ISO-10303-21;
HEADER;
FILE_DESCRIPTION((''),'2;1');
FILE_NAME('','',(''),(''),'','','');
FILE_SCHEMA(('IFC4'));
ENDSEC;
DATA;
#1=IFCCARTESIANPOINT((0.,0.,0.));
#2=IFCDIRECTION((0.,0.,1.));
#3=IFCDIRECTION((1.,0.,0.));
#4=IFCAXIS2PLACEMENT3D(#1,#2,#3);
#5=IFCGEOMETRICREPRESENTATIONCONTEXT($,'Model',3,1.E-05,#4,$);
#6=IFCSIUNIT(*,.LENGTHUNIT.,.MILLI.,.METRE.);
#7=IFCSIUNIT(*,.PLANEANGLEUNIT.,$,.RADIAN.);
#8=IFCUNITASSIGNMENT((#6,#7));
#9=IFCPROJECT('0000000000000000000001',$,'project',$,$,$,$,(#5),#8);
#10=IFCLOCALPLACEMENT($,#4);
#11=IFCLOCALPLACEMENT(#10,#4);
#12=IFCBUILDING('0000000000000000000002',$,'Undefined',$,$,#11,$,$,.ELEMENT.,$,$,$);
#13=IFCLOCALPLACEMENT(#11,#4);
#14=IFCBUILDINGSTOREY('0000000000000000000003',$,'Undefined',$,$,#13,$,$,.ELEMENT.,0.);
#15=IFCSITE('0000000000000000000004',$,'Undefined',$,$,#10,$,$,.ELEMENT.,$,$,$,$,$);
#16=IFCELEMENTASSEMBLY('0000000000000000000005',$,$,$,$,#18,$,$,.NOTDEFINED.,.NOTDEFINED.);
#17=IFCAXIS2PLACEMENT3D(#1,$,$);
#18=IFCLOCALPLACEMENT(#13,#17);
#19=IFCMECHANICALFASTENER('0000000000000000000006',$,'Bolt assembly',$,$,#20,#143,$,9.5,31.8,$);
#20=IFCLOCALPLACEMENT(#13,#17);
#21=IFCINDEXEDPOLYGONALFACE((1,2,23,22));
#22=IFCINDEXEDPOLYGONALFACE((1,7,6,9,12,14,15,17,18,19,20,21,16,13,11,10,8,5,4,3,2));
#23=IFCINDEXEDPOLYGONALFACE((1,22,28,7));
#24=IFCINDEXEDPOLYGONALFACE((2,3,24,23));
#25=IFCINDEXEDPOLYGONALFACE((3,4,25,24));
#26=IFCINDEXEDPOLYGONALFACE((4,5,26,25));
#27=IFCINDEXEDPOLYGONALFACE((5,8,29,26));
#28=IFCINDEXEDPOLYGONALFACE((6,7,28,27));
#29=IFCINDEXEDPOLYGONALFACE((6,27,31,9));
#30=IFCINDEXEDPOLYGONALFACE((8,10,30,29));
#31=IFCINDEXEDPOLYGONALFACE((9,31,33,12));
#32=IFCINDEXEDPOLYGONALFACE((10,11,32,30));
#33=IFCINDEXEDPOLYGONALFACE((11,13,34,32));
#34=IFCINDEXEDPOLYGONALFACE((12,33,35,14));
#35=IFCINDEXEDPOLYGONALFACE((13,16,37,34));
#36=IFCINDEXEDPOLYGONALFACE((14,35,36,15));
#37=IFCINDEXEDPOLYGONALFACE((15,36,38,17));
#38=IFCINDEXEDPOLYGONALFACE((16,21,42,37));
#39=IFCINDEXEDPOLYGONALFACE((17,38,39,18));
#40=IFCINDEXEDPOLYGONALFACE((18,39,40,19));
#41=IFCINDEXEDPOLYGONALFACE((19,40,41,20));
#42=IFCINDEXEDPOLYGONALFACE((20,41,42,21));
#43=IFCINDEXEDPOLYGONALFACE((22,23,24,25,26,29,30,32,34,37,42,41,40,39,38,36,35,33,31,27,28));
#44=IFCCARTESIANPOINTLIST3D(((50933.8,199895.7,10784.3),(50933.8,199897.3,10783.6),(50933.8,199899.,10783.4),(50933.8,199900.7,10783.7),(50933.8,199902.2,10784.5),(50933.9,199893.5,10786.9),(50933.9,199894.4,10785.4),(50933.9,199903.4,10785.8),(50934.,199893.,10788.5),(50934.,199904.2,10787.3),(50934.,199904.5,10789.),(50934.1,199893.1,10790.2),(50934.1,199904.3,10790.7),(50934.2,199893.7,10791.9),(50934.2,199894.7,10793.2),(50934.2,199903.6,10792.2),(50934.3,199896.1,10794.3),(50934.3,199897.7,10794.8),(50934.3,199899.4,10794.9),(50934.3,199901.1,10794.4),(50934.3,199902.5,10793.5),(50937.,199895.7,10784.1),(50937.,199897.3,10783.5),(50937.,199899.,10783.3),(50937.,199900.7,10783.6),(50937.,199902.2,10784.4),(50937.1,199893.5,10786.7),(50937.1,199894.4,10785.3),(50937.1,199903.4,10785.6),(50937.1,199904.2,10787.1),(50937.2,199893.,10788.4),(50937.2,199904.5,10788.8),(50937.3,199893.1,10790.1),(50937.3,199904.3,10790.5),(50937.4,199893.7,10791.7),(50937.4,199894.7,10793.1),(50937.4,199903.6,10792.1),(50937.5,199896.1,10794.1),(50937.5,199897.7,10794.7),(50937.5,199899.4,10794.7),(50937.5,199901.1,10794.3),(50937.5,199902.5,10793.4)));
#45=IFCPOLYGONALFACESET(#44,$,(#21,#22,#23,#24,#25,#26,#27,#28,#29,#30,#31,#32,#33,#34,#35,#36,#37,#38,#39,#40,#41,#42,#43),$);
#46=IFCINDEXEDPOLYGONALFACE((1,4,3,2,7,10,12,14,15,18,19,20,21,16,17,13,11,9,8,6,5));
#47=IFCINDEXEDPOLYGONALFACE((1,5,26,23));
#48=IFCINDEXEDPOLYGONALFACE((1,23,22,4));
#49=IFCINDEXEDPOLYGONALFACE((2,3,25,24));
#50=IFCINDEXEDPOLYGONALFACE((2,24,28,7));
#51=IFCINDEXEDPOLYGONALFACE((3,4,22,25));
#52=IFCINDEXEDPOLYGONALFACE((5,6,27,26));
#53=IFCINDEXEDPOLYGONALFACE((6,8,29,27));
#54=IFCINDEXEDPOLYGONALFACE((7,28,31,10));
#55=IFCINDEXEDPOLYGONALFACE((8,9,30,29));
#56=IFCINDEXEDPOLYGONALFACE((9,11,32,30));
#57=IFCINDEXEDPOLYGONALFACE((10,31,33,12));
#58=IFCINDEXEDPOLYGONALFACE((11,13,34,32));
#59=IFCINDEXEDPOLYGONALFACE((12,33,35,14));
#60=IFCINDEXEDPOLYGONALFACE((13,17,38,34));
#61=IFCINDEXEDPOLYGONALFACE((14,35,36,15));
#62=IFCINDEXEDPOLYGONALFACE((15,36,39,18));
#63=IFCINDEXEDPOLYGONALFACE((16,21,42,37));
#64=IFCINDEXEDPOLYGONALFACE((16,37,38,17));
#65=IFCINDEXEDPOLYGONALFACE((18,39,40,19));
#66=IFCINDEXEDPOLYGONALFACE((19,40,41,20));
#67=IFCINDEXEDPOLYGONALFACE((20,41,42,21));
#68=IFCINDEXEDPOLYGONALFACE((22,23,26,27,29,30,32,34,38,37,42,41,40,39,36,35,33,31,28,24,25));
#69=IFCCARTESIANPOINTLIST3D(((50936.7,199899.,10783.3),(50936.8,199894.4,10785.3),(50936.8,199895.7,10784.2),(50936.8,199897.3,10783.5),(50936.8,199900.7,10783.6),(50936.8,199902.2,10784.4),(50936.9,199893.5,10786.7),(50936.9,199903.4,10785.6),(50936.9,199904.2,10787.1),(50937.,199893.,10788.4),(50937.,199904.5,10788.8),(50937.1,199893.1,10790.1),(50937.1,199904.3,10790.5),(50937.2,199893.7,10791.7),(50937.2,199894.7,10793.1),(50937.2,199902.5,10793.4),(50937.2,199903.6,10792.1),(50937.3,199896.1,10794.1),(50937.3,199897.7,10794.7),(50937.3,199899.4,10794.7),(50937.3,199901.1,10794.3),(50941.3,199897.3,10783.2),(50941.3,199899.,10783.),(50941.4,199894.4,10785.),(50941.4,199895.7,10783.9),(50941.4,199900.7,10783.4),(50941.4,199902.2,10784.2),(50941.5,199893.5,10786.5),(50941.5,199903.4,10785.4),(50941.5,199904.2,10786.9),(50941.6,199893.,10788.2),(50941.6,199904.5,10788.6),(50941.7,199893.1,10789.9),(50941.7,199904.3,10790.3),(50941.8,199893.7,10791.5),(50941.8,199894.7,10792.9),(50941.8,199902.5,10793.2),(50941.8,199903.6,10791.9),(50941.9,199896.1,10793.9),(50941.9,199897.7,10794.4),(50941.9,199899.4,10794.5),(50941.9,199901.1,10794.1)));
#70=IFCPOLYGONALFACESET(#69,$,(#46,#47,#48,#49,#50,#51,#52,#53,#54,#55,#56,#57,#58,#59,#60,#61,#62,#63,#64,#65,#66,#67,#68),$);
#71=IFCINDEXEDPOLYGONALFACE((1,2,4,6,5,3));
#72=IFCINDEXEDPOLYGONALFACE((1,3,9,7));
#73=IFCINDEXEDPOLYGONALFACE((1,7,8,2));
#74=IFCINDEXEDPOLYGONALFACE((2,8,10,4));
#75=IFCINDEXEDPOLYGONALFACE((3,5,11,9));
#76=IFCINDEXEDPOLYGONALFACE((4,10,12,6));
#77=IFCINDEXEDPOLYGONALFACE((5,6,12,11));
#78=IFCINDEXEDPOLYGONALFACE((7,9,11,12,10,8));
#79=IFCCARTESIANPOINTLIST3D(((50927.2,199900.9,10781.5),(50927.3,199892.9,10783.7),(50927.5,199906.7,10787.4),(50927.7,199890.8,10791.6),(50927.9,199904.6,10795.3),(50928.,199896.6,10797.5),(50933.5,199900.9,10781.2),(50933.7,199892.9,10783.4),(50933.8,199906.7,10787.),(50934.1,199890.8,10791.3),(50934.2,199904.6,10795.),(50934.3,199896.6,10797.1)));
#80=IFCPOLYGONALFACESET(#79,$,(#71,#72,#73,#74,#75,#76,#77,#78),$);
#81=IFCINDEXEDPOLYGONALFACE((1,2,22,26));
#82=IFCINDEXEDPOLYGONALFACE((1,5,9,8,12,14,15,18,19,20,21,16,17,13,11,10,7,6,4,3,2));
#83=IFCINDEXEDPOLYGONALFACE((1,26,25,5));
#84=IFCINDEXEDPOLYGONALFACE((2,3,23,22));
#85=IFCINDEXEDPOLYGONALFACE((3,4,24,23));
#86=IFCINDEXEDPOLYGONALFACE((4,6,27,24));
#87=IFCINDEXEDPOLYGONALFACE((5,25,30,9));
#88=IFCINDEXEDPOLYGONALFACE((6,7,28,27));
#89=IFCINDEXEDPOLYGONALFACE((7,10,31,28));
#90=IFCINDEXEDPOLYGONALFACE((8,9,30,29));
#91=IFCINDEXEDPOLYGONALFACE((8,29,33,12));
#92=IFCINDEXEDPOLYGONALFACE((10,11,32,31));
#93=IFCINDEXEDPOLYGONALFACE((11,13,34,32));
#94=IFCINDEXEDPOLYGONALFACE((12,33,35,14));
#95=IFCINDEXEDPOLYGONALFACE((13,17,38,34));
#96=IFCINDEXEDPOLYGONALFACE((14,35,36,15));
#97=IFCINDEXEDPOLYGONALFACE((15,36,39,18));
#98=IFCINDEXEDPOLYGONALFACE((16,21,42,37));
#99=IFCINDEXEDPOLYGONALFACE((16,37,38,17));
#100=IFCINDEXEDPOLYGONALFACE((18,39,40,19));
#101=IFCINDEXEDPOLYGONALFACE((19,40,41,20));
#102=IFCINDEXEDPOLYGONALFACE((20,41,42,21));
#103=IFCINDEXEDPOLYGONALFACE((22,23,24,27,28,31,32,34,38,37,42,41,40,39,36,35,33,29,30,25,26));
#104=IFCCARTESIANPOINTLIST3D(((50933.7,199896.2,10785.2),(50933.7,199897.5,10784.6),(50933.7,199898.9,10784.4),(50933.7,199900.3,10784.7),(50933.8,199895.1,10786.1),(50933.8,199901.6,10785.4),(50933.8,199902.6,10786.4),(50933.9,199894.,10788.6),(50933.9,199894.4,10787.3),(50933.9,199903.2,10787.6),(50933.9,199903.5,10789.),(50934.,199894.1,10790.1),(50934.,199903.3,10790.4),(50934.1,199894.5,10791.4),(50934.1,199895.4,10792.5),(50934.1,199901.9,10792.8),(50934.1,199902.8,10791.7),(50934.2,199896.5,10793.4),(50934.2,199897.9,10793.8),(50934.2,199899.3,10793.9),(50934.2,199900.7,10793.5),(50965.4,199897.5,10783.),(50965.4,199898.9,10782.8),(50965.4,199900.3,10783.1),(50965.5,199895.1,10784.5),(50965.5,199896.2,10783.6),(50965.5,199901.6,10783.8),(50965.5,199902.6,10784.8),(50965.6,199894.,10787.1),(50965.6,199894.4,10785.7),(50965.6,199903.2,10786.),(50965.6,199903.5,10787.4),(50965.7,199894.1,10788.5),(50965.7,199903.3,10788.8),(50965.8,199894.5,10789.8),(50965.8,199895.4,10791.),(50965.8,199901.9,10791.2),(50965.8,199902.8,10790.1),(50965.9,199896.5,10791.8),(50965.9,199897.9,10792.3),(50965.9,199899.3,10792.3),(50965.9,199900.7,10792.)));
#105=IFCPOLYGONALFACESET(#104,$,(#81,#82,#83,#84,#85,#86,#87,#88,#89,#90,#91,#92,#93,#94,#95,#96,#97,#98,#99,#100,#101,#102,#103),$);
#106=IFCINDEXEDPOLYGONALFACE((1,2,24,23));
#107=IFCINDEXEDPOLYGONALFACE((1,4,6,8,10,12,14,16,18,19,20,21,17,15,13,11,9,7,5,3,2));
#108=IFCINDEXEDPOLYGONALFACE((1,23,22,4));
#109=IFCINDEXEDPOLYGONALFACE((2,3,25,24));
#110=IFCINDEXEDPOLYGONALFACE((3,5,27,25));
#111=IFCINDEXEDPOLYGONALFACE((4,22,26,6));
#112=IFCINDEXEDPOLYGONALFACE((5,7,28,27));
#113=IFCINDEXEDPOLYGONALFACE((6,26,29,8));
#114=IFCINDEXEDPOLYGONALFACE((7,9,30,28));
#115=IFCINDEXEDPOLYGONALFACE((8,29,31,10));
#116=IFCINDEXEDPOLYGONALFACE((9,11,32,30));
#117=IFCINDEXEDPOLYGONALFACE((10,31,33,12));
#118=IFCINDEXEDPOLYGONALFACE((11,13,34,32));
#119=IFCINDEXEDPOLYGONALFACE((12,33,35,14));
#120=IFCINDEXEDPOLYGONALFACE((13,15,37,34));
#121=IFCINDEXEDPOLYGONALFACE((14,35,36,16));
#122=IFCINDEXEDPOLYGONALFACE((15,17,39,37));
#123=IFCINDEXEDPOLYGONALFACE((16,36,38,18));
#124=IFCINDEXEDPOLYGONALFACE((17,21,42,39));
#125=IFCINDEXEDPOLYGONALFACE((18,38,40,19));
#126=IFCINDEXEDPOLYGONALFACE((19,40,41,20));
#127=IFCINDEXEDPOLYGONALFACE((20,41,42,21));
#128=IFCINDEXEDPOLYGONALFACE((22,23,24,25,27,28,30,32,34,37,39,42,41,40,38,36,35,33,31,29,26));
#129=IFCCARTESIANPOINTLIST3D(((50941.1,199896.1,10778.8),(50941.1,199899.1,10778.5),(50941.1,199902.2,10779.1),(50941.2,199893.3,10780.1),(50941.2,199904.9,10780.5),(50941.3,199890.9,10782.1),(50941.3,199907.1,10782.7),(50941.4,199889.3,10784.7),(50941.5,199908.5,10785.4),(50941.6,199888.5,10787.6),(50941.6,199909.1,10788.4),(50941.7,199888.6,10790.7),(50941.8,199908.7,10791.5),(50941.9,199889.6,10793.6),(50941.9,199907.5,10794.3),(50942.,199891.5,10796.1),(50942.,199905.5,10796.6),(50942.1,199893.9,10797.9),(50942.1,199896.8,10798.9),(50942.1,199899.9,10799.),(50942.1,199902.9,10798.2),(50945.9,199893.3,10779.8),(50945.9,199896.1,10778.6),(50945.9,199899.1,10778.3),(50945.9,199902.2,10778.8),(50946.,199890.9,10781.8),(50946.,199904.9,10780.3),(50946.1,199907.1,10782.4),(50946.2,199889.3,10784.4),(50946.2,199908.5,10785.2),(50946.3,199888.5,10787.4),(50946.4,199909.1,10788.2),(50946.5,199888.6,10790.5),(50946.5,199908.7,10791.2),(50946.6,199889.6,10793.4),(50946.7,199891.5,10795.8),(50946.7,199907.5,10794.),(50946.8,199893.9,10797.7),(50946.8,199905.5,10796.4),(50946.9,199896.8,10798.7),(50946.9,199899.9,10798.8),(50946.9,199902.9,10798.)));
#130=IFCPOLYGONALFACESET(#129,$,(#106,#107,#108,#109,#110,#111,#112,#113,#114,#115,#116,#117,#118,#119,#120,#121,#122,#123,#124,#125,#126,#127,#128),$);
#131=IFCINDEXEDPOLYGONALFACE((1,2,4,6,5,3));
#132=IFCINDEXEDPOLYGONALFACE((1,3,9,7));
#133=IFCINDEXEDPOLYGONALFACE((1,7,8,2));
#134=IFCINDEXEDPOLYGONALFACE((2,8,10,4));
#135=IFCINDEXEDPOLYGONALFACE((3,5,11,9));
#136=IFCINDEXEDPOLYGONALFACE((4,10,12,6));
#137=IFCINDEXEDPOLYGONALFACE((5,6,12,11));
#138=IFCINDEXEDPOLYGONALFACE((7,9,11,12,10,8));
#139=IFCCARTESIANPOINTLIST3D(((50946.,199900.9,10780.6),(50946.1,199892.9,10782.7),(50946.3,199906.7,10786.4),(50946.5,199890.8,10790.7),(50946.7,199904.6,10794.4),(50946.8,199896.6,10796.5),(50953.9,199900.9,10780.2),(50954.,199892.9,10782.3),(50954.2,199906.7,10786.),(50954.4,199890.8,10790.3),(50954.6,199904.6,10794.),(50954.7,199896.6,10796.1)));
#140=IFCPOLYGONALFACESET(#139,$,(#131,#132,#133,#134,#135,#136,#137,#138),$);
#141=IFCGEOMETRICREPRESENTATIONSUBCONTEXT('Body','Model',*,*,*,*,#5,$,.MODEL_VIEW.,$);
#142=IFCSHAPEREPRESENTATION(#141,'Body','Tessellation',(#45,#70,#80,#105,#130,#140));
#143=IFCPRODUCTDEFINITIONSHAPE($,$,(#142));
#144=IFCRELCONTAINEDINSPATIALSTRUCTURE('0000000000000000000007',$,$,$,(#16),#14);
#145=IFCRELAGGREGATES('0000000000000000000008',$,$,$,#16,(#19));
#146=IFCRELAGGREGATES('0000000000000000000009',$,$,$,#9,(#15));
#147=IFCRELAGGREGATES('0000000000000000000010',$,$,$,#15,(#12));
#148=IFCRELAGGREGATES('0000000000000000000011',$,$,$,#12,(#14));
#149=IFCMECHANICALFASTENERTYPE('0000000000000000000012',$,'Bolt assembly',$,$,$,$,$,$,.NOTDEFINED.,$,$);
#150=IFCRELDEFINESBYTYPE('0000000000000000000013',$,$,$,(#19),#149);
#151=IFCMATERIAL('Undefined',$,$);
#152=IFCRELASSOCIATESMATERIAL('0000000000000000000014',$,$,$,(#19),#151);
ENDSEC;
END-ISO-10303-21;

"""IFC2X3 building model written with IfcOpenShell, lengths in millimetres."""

from ifc_helpers import new_model, si_unit, frame, origin_with_axes, origin_2d_with_axis, place, context, subcontext, project, spatial, polyline, circle, outline, extrude, source, transform, mapped, material, type_object, element, aggregate, save


model = new_model("IFC2X3")

# Units and contexts
model_context = context("Model", 3, precision=1e-05, world=origin_with_axes())
body_context = subcontext(model_context, "Body", "Model", "MODEL_VIEW")
ifc_project = project(units=[si_unit("LENGTHUNIT", "METRE", prefix="MILLI"), si_unit("PLANEANGLEUNIT", "RADIAN")], contexts=[model_context])

# Site, building, storey
site_placement = place(None, origin_with_axes())
site = spatial("IfcSite", under=ifc_project, at=site_placement, Name="Undefined", CompositionType="ELEMENT")
building_placement = place(site_placement, origin_with_axes())
building = spatial("IfcBuilding", under=site, at=building_placement, Name="Undefined", CompositionType="ELEMENT")
storey_placement = place(building_placement, origin_with_axes())
storey = spatial("IfcBuildingStorey", under=building, at=storey_placement, Name="Undefined", CompositionType="ELEMENT", Elevation=0.0)

# Shared definitions
ifc_material_1 = material(Name="Undefined")
mechanical_fastener_type = type_object("IfcMechanicalFastenerType", Name="Bolt assembly")

# Element assembly, mechanical fastener
assembly_1_placement = place(storey_placement, origin_with_axes())
assembly_1 = element("IfcElementAssembly", 1, at=assembly_1_placement, inside=storey, AssemblyPlace="NOTDEFINED", PredefinedType="NOTDEFINED")
shared_shape_1 = source(origin_with_axes(), body_context, "Body", "SweptSolid", [
    extrude(circle(Radius=5.8, at=origin_2d_with_axis()), frame((0.0, -7.6, 0.0), z_axis=(0.0, 1.0, 0.0), x_axis=(1.0, 0.0, 0.0)), (0.0, 0.0, 1.0), 3.2),
    extrude(circle(Radius=5.8, at=origin_2d_with_axis()), frame((0.0, -4.6, 0.0), z_axis=(0.0, 1.0, 0.0), x_axis=(1.0, 0.0, 0.0)), (0.0, 0.0, 1.0), 4.6),
    extrude(outline(polyline([(7.1, -4.1), (7.1, 4.1), (0.0, 8.2), (-7.1, 4.1), (-7.1, -4.1), (0.0, -8.2), (7.1, -4.1)])), frame((0.0, -14.0, 0.0), z_axis=(0.0, 1.0, 0.0), x_axis=(1.0, 0.0, 0.0)), (0.0, 0.0, 1.0), 6.3),
    extrude(circle(Radius=4.8, at=origin_2d_with_axis()), frame((0.0, -7.7, 0.0), z_axis=(0.0, 1.0, 0.0), x_axis=(1.0, 0.0, 0.0)), (0.0, 0.0, 1.0), 31.8),
    extrude(circle(Radius=10.3, at=origin_2d_with_axis()), frame((0.0, 0.0, 0.0), z_axis=(0.0, 1.0, 0.0), x_axis=(1.0, 0.0, 0.0)), (0.0, 0.0, 1.0), 4.8),
    extrude(outline(polyline([(7.1, -4.1), (7.1, 4.1), (0.0, 8.2), (-7.1, 4.1), (-7.1, -4.1), (0.0, -8.2), (7.1, -4.1)])), frame((0.0, 4.8, 0.0), z_axis=(0.0, 1.0, 0.0), x_axis=(1.0, 0.0, 0.0)), (0.0, 0.0, 1.0), 7.9),
])
mechanical_fastener_1_placement = place(assembly_1_placement, frame((50941.6, 199898.8, 10788.8), z_axis=(0.035281, 0.707107, 0.706226), x_axis=(0.035282, -0.707107, 0.706226)))
mechanical_fastener_1 = element("IfcMechanicalFastener", 2, at=mechanical_fastener_1_placement, type_object=mechanical_fastener_type, material=ifc_material_1, Name="Bolt assembly", NominalDiameter=9.5, NominalLength=31.8, context=body_context, shape_type="MappedRepresentation", body=[
    mapped(shared_shape_1, transform((0.0, 0.0, 0.0))),
])
aggregate(assembly_1, [mechanical_fastener_1])

save(model, "model.ifc")
